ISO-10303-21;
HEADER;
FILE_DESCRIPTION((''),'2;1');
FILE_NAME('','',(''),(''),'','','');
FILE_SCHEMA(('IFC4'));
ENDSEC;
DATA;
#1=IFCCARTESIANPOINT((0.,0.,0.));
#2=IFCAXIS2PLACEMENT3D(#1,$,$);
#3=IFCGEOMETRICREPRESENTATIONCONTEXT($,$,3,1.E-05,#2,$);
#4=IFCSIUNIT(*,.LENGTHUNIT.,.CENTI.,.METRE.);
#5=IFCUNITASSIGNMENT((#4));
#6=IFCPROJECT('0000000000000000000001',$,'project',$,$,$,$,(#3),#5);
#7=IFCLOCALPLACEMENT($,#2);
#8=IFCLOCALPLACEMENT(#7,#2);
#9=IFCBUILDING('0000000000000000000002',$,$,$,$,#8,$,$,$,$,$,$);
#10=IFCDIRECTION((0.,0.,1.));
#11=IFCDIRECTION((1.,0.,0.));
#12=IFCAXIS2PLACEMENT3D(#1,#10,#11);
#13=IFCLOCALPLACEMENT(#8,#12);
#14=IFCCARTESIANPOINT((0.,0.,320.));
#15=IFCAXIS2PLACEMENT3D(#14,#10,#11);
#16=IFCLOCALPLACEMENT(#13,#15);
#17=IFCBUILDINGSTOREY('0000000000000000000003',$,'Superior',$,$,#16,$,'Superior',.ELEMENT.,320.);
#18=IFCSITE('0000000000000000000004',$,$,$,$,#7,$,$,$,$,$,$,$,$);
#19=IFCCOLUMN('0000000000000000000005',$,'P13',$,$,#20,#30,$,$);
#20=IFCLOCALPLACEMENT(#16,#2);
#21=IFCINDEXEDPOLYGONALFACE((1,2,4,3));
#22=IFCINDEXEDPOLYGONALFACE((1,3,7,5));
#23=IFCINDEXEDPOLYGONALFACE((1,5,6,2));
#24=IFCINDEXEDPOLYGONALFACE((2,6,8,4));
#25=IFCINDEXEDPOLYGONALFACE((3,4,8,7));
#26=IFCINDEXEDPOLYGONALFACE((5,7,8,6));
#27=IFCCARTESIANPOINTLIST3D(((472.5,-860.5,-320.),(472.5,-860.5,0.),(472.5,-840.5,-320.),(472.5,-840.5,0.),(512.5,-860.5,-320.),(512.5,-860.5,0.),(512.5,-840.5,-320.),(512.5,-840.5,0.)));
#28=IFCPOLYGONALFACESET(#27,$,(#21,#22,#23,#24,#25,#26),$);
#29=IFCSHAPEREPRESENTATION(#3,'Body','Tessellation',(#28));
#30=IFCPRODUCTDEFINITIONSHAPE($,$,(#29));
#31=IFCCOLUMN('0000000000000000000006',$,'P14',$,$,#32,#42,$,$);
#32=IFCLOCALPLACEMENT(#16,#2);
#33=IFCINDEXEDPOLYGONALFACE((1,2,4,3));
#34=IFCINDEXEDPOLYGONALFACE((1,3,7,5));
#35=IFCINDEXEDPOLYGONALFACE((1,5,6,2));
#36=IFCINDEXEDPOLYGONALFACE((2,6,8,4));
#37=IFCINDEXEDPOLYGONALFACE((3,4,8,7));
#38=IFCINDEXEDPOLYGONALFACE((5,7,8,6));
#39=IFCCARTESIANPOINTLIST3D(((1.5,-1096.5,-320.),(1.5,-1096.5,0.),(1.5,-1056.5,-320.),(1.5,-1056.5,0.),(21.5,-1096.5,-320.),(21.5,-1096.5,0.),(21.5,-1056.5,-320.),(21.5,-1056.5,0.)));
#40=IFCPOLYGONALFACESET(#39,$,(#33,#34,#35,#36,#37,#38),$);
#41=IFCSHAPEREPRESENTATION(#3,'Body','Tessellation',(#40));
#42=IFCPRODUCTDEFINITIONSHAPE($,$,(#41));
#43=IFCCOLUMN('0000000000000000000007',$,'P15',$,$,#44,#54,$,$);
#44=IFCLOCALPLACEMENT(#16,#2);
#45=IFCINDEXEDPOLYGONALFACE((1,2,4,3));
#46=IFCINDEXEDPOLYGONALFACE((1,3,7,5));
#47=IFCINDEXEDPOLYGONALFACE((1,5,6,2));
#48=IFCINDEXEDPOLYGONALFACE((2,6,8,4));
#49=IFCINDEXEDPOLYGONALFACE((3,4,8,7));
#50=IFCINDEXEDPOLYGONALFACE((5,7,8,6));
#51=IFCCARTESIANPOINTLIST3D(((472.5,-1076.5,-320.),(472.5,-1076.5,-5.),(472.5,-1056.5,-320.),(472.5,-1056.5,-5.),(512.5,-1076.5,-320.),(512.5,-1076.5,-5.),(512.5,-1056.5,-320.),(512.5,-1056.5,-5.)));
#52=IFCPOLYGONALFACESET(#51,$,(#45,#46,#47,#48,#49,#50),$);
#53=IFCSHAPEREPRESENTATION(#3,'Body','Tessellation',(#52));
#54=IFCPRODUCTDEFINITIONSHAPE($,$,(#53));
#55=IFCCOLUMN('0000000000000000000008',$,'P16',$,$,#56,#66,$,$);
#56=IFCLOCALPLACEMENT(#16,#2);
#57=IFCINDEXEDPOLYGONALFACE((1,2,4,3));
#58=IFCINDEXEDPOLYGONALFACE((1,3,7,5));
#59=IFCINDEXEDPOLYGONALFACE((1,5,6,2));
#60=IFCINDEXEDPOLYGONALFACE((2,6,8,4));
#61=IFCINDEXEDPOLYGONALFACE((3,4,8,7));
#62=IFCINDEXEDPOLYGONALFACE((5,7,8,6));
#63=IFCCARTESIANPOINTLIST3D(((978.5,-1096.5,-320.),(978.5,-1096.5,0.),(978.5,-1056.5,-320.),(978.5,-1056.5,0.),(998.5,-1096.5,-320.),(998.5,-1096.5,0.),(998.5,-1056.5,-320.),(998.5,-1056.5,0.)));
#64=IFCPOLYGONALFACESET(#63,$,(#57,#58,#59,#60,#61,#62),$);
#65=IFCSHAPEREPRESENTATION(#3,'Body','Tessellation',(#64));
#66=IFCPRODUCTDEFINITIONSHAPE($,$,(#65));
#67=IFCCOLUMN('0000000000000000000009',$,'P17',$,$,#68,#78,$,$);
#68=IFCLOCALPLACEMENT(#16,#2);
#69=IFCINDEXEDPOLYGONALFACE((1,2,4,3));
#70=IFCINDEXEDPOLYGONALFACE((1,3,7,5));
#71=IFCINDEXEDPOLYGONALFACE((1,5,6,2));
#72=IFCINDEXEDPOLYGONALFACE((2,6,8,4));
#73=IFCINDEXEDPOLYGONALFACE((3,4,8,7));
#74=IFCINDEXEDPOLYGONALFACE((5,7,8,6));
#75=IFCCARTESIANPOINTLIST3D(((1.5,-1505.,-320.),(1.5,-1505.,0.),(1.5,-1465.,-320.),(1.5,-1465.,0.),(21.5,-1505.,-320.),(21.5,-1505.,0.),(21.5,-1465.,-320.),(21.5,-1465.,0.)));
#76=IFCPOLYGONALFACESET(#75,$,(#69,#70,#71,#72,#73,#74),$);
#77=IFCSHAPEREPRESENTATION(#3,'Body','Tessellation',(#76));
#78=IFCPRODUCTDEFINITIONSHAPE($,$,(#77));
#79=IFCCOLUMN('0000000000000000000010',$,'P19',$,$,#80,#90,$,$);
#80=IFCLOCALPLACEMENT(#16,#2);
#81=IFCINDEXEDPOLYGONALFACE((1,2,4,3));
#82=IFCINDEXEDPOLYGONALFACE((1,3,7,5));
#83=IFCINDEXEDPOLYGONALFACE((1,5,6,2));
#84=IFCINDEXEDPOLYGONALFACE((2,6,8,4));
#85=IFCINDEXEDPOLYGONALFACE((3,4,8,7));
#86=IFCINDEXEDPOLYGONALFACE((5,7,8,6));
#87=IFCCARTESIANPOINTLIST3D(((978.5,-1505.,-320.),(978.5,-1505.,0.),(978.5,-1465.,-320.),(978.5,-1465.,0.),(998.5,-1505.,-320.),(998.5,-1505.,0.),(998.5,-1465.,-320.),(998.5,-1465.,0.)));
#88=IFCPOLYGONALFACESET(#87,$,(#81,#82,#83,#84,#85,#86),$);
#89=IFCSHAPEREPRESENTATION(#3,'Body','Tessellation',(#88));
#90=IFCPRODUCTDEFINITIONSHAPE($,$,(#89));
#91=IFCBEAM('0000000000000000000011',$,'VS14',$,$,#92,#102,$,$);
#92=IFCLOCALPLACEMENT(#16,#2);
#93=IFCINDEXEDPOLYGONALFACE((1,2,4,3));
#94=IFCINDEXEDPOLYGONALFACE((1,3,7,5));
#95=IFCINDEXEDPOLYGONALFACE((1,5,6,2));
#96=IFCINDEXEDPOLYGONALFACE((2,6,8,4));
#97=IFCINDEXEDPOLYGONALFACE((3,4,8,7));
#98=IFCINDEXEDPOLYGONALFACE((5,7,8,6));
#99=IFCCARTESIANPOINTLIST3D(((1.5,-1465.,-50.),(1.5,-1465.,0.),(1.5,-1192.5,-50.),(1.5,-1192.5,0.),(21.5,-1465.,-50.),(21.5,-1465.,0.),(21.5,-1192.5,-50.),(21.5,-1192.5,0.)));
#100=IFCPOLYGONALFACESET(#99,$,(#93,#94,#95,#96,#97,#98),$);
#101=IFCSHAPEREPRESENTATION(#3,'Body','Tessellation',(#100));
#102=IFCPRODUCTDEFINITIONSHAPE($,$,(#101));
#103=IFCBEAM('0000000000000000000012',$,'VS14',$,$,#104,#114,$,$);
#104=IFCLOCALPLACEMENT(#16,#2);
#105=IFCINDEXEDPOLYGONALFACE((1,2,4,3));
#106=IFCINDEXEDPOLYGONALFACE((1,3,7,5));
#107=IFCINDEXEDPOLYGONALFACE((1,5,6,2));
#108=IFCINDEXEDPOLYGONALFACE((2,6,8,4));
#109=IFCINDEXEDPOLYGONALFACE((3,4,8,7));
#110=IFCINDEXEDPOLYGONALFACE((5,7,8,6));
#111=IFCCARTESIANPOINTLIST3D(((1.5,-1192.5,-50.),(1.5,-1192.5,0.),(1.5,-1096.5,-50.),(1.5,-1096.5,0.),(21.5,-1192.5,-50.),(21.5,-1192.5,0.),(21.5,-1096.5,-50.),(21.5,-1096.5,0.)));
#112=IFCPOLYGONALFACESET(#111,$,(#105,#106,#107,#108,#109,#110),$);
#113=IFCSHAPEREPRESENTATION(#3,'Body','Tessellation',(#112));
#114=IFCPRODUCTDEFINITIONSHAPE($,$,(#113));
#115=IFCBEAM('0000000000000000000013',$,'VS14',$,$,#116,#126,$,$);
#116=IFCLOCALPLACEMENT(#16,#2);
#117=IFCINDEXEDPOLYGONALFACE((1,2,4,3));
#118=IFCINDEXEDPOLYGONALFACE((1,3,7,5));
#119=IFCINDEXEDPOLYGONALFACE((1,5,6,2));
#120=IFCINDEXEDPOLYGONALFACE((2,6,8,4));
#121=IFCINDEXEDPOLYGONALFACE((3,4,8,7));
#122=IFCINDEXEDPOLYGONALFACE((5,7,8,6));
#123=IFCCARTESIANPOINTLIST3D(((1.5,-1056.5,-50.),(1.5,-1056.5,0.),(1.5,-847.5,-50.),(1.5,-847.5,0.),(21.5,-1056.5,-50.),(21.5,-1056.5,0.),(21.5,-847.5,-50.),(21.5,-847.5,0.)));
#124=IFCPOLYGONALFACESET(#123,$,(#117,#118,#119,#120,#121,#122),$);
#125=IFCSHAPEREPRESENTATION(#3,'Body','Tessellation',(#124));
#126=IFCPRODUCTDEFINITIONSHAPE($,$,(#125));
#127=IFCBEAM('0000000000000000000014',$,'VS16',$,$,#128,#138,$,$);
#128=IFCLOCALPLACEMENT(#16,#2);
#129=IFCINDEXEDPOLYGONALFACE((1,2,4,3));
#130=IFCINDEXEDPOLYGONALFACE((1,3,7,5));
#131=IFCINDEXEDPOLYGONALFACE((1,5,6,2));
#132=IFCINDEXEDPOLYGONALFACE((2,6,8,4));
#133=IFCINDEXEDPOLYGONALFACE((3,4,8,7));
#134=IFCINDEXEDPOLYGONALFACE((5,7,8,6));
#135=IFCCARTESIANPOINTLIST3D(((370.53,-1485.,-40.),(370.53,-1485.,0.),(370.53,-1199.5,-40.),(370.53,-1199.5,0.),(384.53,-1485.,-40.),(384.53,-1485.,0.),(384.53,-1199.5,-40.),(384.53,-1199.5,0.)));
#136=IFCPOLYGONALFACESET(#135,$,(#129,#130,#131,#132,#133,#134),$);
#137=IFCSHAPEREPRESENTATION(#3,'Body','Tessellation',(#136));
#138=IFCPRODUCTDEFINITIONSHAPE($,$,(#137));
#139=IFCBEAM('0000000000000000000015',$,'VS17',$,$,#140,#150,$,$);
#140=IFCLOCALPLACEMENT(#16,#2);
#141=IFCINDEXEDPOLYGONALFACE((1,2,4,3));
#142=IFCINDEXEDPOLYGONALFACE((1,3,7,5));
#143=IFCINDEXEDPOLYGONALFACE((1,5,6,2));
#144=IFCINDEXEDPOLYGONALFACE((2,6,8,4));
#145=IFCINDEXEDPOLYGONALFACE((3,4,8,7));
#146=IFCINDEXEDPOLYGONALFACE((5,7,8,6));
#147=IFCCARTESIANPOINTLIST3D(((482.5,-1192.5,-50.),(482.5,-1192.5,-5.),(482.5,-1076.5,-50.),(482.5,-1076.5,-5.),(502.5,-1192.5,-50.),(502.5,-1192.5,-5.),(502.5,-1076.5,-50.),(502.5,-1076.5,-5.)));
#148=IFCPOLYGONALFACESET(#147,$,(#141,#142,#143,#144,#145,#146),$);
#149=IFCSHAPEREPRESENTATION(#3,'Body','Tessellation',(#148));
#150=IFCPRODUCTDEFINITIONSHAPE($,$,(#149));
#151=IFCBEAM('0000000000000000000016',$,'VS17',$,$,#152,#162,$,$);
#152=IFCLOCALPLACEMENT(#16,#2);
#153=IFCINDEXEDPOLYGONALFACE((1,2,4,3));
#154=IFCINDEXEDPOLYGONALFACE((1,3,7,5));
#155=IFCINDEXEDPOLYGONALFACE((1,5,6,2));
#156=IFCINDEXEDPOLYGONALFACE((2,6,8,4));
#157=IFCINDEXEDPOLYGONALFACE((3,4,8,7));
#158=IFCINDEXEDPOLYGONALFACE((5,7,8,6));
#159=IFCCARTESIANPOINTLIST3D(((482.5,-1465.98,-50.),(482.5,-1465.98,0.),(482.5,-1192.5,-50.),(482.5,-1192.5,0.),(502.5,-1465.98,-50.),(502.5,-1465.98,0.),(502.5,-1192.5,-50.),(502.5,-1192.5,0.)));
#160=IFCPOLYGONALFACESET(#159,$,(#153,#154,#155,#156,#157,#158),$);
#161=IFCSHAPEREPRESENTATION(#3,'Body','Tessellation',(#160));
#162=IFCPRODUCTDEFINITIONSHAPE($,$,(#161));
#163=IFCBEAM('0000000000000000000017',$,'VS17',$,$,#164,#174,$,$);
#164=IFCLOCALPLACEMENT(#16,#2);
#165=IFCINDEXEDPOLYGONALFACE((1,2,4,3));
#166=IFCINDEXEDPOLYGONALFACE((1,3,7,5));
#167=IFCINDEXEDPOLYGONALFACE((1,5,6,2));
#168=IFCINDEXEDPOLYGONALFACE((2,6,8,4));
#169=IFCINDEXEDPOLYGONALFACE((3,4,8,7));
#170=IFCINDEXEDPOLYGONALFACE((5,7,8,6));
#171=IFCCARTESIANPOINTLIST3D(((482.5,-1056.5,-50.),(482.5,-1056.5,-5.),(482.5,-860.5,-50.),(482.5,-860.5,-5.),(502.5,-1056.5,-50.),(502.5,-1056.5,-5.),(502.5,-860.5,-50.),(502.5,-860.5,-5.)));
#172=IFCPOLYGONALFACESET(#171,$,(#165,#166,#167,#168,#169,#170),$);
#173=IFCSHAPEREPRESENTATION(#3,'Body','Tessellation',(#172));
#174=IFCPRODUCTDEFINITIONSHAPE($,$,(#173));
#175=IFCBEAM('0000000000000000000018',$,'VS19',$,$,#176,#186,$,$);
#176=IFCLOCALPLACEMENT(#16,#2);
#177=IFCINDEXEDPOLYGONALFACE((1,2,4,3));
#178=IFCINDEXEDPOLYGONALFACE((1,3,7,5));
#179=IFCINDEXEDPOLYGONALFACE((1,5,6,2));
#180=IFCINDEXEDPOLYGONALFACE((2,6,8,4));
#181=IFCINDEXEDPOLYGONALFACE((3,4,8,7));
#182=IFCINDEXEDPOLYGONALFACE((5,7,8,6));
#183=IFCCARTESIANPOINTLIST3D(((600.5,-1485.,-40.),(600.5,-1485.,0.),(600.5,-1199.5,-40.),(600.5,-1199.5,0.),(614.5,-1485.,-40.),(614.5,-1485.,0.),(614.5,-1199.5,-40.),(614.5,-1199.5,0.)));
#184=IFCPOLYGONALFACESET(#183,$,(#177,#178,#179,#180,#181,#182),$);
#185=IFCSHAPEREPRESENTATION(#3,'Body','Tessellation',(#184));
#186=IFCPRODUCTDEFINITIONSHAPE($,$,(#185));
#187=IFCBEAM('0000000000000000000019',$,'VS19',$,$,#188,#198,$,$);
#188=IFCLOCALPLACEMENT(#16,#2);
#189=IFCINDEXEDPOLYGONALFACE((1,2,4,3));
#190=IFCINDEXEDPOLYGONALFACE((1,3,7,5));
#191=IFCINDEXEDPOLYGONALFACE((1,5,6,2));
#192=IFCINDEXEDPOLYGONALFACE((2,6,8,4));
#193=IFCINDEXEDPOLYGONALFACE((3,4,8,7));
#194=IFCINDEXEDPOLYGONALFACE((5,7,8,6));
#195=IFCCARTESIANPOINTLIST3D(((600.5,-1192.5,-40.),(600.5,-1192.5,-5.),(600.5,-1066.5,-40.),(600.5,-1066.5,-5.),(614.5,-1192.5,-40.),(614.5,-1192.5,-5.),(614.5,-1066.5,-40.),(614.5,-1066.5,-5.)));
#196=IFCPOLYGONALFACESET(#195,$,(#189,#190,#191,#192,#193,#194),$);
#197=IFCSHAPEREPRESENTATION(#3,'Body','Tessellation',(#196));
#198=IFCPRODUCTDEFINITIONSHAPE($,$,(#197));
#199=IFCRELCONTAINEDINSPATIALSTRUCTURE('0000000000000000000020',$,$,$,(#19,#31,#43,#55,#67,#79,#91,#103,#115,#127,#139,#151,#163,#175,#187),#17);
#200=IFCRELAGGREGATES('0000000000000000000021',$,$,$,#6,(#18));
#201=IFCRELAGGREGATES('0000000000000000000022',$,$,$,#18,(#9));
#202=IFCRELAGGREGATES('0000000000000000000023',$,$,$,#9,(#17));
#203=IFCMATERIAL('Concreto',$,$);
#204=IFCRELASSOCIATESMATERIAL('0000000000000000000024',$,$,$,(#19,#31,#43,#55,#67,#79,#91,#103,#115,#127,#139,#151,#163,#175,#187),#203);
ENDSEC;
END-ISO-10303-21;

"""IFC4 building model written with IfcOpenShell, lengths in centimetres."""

from ifc_helpers import new_model, si_unit, frame, origin, origin_with_axes, place, context, project, spatial, polyline, outline, extrude, material, element, save


model = new_model("IFC4")

# Units and contexts
context_of_model = context(None, 3, precision=1e-05, world=origin())
ifc_project = project(units=[si_unit("LENGTHUNIT", "METRE", prefix="CENTI")], contexts=[context_of_model])

# Site, building, storey
site_placement = place(None, origin())
site = spatial("IfcSite", under=ifc_project, at=site_placement)
building_placement = place(site_placement, origin())
building = spatial("IfcBuilding", under=site, at=building_placement)
placement = place(building_placement, origin_with_axes())
storey_placement = place(placement, frame((0.0, 0.0, 320.0), z_axis=(0.0, 0.0, 1.0), x_axis=(1.0, 0.0, 0.0)))
storey = spatial("IfcBuildingStorey", under=building, at=storey_placement, Name="Superior", LongName="Superior", CompositionType="ELEMENT", Elevation=320.0)

# Columns
ifc_material = material(Name="Concreto")
column_1_placement = place(storey_placement, frame((492.5, -850.5, 0.0), z_axis=(0.0, 0.0, 1.0), x_axis=(1.0, 0.0, 0.0)))
element("IfcColumn", 1, at=column_1_placement, inside=storey, material=ifc_material, Name="P13", context=context_of_model, shape_type="SolidModel", body=[
    extrude(outline(polyline([(-20.0, 10.0), (-20.0, -10.0), (20.0, -10.0), (20.0, 10.0), (-20.0, 10.0)])), origin_with_axes(), (0.0, 0.0, -1.0), 320.0),
])
column_2_placement = place(storey_placement, frame((11.5, -1076.5, 0.0), z_axis=(0.0, 0.0, 1.0), x_axis=(1.0, 0.0, 0.0)))
element("IfcColumn", 2, at=column_2_placement, inside=storey, material=ifc_material, Name="P14", context=context_of_model, shape_type="SolidModel", body=[
    extrude(outline(polyline([(10.0, 20.0), (-10.0, 20.0), (-10.0, -20.0), (10.0, -20.0), (10.0, 20.0)])), frame((0.0, 0.0, 0.0), z_axis=(0.0, 0.0, 1.0), x_axis=(1.0, 0.0, 0.0)), (0.0, 0.0, -1.0), 320.0),
])
column_3_placement = place(storey_placement, frame((492.5, -1066.5, -5.0), z_axis=(0.0, 0.0, 1.0), x_axis=(1.0, 0.0, 0.0)))
element("IfcColumn", 3, at=column_3_placement, inside=storey, material=ifc_material, Name="P15", context=context_of_model, shape_type="SolidModel", body=[
    extrude(outline(polyline([(-20.0, 10.0), (-20.0, -10.0), (20.0, -10.0), (20.0, 10.0), (-20.0, 10.0)])), origin_with_axes(), (0.0, 0.0, -1.0), 315.0),
])
column_4_placement = place(storey_placement, frame((988.5, -1076.5, 0.0), z_axis=(0.0, 0.0, 1.0), x_axis=(1.0, 0.0, 0.0)))
element("IfcColumn", 4, at=column_4_placement, inside=storey, material=ifc_material, Name="P16", context=context_of_model, shape_type="SolidModel", body=[
    extrude(outline(polyline([(-10.0, -20.0), (10.0, -20.0), (10.0, 20.0), (-10.0, 20.0), (-10.0, -20.0)])), origin_with_axes(), (0.0, 0.0, -1.0), 320.0),
])
column_5_placement = place(storey_placement, frame((11.5, -1485.0, 0.0), z_axis=(0.0, 0.0, 1.0), x_axis=(1.0, 0.0, 0.0)))
element("IfcColumn", 5, at=column_5_placement, inside=storey, material=ifc_material, Name="P17", context=context_of_model, shape_type="SolidModel", body=[
    extrude(outline(polyline([(-10.0, -20.0), (10.0, -20.0), (10.0, 20.0), (-10.0, 20.0), (-10.0, -20.0)])), frame((0.0, 0.0, 0.0), z_axis=(0.0, 0.0, 1.0), x_axis=(1.0, 0.0, 0.0)), (0.0, 0.0, -1.0), 320.0),
])
column_6_placement = place(storey_placement, frame((988.5, -1485.0, 0.0), z_axis=(0.0, 0.0, 1.0), x_axis=(1.0, 0.0, 0.0)))
element("IfcColumn", 6, at=column_6_placement, inside=storey, material=ifc_material, Name="P19", context=context_of_model, shape_type="SolidModel", body=[
    extrude(outline(polyline([(10.0, 20.0), (-10.0, 20.0), (-10.0, -20.0), (10.0, -20.0), (10.0, 20.0)])), origin_with_axes(), (0.0, 0.0, -1.0), 320.0),
])

# Beams
beam_1_placement = place(storey_placement, frame((11.5, -1328.75, 0.0), z_axis=(0.0, 0.0, 1.0), x_axis=(1.0, 0.0, 0.0)))
element("IfcBeam", 7, at=beam_1_placement, inside=storey, material=ifc_material, Name="VS14", context=context_of_model, shape_type="SolidModel", body=[
    extrude(outline(polyline([(-10.0, -25.0), (10.0, -25.0), (10.0, 25.0), (-10.0, 25.0), (-10.0, -25.0)])), frame((0.0, -136.25, -25.0), z_axis=(0.0, 1.0, 0.0), x_axis=(1.0, 0.0, 0.0)), (0.0, 0.0, 1.0), 272.5),
])
beam_2_placement = place(storey_placement, frame((11.5, -1144.5, 0.0), z_axis=(0.0, 0.0, 1.0), x_axis=(1.0, 0.0, 0.0)))
element("IfcBeam", 8, at=beam_2_placement, inside=storey, material=ifc_material, Name="VS14", context=context_of_model, shape_type="SolidModel", body=[
    extrude(outline(polyline([(-10.0, -25.0), (10.0, -25.0), (10.0, 25.0), (-10.0, 25.0), (-10.0, -25.0)])), frame((0.0, -48.0, -25.0), z_axis=(0.0, 1.0, 0.0), x_axis=(1.0, 0.0, 0.0)), (0.0, 0.0, 1.0), 96.0),
])
beam_3_placement = place(storey_placement, frame((11.5, -952.0, 0.0), z_axis=(0.0, 0.0, 1.0), x_axis=(1.0, 0.0, 0.0)))
element("IfcBeam", 9, at=beam_3_placement, inside=storey, material=ifc_material, Name="VS14", context=context_of_model, shape_type="SolidModel", body=[
    extrude(outline(polyline([(-10.0, -25.0), (10.0, -25.0), (10.0, 25.0), (-10.0, 25.0), (-10.0, -25.0)])), frame((0.0, -104.5, -25.0), z_axis=(0.0, 1.0, 0.0), x_axis=(1.0, 0.0, 0.0)), (0.0, 0.0, 1.0), 209.0),
])
beam_4_placement = place(storey_placement, frame((377.53, -1342.25, 0.0), z_axis=(0.0, 0.0, 1.0), x_axis=(1.0, 0.0, 0.0)))
element("IfcBeam", 10, at=beam_4_placement, inside=storey, material=ifc_material, Name="VS16", context=context_of_model, shape_type="SolidModel", body=[
    extrude(outline(polyline([(-7.0, -20.0), (7.0, -20.0), (7.0, 20.0), (-7.0, 20.0), (-7.0, -20.0)])), frame((0.0, -142.75, -20.0), z_axis=(0.0, 1.0, 0.0), x_axis=(1.0, 0.0, 0.0)), (0.0, 0.0, 1.0), 285.5),
])
beam_5_placement = place(storey_placement, frame((492.5, -1134.5, -5.0), z_axis=(0.0, 0.0, 1.0), x_axis=(1.0, 0.0, 0.0)))
element("IfcBeam", 11, at=beam_5_placement, inside=storey, material=ifc_material, Name="VS17", context=context_of_model, shape_type="SolidModel", body=[
    extrude(outline(polyline([(-10.0, -22.5), (10.0, -22.5), (10.0, 22.5), (-10.0, 22.5), (-10.0, -22.5)])), frame((0.0, -58.0, -22.5), z_axis=(0.0, 1.0, 0.0), x_axis=(1.0, 0.0, 0.0)), (0.0, 0.0, 1.0), 116.0),
])
beam_6_placement = place(storey_placement, frame((492.5, -1329.24, 0.0), z_axis=(0.0, 0.0, 1.0), x_axis=(1.0, 0.0, 0.0)))
element("IfcBeam", 12, at=beam_6_placement, inside=storey, material=ifc_material, Name="VS17", context=context_of_model, shape_type="SolidModel", body=[
    extrude(outline(polyline([(-10.0, -25.0), (10.0, -25.0), (10.0, 25.0), (-10.0, 25.0), (-10.0, -25.0)])), frame((0.0, -136.75, -25.0), z_axis=(0.0, 1.0, 0.0), x_axis=(1.0, 0.0, 0.0)), (0.0, 0.0, 1.0), 273.49),
])
beam_7_placement = place(storey_placement, frame((492.5, -958.5, -5.0), z_axis=(0.0, 0.0, 1.0), x_axis=(1.0, 0.0, 0.0)))
element("IfcBeam", 13, at=beam_7_placement, inside=storey, material=ifc_material, Name="VS17", context=context_of_model, shape_type="SolidModel", body=[
    extrude(outline(polyline([(-10.0, -22.5), (10.0, -22.5), (10.0, 22.5), (-10.0, 22.5), (-10.0, -22.5)])), frame((0.0, -98.0, -22.5), z_axis=(0.0, 1.0, 0.0), x_axis=(1.0, 0.0, 0.0)), (0.0, 0.0, 1.0), 196.0),
])
beam_8_placement = place(storey_placement, frame((607.5, -1342.25, 0.0), z_axis=(0.0, 0.0, 1.0), x_axis=(1.0, 0.0, 0.0)))
element("IfcBeam", 14, at=beam_8_placement, inside=storey, material=ifc_material, Name="VS19", context=context_of_model, shape_type="SolidModel", body=[
    extrude(outline(polyline([(-7.0, -20.0), (7.0, -20.0), (7.0, 20.0), (-7.0, 20.0), (-7.0, -20.0)])), frame((0.0, -142.75, -20.0), z_axis=(0.0, 1.0, 0.0), x_axis=(1.0, 0.0, 0.0)), (0.0, 0.0, 1.0), 285.5),
])
beam_9_placement = place(storey_placement, frame((607.5, -1129.5, -5.0), z_axis=(0.0, 0.0, 1.0), x_axis=(1.0, 0.0, 0.0)))
element("IfcBeam", 15, at=beam_9_placement, inside=storey, material=ifc_material, Name="VS19", context=context_of_model, shape_type="SolidModel", body=[
    extrude(outline(polyline([(-7.0, -17.5), (7.0, -17.5), (7.0, 17.5), (-7.0, 17.5), (-7.0, -17.5)])), frame((0.0, -63.0, -17.5), z_axis=(0.0, 1.0, 0.0), x_axis=(1.0, 0.0, 0.0)), (0.0, 0.0, 1.0), 126.0),
])

save(model, "model.ifc")
